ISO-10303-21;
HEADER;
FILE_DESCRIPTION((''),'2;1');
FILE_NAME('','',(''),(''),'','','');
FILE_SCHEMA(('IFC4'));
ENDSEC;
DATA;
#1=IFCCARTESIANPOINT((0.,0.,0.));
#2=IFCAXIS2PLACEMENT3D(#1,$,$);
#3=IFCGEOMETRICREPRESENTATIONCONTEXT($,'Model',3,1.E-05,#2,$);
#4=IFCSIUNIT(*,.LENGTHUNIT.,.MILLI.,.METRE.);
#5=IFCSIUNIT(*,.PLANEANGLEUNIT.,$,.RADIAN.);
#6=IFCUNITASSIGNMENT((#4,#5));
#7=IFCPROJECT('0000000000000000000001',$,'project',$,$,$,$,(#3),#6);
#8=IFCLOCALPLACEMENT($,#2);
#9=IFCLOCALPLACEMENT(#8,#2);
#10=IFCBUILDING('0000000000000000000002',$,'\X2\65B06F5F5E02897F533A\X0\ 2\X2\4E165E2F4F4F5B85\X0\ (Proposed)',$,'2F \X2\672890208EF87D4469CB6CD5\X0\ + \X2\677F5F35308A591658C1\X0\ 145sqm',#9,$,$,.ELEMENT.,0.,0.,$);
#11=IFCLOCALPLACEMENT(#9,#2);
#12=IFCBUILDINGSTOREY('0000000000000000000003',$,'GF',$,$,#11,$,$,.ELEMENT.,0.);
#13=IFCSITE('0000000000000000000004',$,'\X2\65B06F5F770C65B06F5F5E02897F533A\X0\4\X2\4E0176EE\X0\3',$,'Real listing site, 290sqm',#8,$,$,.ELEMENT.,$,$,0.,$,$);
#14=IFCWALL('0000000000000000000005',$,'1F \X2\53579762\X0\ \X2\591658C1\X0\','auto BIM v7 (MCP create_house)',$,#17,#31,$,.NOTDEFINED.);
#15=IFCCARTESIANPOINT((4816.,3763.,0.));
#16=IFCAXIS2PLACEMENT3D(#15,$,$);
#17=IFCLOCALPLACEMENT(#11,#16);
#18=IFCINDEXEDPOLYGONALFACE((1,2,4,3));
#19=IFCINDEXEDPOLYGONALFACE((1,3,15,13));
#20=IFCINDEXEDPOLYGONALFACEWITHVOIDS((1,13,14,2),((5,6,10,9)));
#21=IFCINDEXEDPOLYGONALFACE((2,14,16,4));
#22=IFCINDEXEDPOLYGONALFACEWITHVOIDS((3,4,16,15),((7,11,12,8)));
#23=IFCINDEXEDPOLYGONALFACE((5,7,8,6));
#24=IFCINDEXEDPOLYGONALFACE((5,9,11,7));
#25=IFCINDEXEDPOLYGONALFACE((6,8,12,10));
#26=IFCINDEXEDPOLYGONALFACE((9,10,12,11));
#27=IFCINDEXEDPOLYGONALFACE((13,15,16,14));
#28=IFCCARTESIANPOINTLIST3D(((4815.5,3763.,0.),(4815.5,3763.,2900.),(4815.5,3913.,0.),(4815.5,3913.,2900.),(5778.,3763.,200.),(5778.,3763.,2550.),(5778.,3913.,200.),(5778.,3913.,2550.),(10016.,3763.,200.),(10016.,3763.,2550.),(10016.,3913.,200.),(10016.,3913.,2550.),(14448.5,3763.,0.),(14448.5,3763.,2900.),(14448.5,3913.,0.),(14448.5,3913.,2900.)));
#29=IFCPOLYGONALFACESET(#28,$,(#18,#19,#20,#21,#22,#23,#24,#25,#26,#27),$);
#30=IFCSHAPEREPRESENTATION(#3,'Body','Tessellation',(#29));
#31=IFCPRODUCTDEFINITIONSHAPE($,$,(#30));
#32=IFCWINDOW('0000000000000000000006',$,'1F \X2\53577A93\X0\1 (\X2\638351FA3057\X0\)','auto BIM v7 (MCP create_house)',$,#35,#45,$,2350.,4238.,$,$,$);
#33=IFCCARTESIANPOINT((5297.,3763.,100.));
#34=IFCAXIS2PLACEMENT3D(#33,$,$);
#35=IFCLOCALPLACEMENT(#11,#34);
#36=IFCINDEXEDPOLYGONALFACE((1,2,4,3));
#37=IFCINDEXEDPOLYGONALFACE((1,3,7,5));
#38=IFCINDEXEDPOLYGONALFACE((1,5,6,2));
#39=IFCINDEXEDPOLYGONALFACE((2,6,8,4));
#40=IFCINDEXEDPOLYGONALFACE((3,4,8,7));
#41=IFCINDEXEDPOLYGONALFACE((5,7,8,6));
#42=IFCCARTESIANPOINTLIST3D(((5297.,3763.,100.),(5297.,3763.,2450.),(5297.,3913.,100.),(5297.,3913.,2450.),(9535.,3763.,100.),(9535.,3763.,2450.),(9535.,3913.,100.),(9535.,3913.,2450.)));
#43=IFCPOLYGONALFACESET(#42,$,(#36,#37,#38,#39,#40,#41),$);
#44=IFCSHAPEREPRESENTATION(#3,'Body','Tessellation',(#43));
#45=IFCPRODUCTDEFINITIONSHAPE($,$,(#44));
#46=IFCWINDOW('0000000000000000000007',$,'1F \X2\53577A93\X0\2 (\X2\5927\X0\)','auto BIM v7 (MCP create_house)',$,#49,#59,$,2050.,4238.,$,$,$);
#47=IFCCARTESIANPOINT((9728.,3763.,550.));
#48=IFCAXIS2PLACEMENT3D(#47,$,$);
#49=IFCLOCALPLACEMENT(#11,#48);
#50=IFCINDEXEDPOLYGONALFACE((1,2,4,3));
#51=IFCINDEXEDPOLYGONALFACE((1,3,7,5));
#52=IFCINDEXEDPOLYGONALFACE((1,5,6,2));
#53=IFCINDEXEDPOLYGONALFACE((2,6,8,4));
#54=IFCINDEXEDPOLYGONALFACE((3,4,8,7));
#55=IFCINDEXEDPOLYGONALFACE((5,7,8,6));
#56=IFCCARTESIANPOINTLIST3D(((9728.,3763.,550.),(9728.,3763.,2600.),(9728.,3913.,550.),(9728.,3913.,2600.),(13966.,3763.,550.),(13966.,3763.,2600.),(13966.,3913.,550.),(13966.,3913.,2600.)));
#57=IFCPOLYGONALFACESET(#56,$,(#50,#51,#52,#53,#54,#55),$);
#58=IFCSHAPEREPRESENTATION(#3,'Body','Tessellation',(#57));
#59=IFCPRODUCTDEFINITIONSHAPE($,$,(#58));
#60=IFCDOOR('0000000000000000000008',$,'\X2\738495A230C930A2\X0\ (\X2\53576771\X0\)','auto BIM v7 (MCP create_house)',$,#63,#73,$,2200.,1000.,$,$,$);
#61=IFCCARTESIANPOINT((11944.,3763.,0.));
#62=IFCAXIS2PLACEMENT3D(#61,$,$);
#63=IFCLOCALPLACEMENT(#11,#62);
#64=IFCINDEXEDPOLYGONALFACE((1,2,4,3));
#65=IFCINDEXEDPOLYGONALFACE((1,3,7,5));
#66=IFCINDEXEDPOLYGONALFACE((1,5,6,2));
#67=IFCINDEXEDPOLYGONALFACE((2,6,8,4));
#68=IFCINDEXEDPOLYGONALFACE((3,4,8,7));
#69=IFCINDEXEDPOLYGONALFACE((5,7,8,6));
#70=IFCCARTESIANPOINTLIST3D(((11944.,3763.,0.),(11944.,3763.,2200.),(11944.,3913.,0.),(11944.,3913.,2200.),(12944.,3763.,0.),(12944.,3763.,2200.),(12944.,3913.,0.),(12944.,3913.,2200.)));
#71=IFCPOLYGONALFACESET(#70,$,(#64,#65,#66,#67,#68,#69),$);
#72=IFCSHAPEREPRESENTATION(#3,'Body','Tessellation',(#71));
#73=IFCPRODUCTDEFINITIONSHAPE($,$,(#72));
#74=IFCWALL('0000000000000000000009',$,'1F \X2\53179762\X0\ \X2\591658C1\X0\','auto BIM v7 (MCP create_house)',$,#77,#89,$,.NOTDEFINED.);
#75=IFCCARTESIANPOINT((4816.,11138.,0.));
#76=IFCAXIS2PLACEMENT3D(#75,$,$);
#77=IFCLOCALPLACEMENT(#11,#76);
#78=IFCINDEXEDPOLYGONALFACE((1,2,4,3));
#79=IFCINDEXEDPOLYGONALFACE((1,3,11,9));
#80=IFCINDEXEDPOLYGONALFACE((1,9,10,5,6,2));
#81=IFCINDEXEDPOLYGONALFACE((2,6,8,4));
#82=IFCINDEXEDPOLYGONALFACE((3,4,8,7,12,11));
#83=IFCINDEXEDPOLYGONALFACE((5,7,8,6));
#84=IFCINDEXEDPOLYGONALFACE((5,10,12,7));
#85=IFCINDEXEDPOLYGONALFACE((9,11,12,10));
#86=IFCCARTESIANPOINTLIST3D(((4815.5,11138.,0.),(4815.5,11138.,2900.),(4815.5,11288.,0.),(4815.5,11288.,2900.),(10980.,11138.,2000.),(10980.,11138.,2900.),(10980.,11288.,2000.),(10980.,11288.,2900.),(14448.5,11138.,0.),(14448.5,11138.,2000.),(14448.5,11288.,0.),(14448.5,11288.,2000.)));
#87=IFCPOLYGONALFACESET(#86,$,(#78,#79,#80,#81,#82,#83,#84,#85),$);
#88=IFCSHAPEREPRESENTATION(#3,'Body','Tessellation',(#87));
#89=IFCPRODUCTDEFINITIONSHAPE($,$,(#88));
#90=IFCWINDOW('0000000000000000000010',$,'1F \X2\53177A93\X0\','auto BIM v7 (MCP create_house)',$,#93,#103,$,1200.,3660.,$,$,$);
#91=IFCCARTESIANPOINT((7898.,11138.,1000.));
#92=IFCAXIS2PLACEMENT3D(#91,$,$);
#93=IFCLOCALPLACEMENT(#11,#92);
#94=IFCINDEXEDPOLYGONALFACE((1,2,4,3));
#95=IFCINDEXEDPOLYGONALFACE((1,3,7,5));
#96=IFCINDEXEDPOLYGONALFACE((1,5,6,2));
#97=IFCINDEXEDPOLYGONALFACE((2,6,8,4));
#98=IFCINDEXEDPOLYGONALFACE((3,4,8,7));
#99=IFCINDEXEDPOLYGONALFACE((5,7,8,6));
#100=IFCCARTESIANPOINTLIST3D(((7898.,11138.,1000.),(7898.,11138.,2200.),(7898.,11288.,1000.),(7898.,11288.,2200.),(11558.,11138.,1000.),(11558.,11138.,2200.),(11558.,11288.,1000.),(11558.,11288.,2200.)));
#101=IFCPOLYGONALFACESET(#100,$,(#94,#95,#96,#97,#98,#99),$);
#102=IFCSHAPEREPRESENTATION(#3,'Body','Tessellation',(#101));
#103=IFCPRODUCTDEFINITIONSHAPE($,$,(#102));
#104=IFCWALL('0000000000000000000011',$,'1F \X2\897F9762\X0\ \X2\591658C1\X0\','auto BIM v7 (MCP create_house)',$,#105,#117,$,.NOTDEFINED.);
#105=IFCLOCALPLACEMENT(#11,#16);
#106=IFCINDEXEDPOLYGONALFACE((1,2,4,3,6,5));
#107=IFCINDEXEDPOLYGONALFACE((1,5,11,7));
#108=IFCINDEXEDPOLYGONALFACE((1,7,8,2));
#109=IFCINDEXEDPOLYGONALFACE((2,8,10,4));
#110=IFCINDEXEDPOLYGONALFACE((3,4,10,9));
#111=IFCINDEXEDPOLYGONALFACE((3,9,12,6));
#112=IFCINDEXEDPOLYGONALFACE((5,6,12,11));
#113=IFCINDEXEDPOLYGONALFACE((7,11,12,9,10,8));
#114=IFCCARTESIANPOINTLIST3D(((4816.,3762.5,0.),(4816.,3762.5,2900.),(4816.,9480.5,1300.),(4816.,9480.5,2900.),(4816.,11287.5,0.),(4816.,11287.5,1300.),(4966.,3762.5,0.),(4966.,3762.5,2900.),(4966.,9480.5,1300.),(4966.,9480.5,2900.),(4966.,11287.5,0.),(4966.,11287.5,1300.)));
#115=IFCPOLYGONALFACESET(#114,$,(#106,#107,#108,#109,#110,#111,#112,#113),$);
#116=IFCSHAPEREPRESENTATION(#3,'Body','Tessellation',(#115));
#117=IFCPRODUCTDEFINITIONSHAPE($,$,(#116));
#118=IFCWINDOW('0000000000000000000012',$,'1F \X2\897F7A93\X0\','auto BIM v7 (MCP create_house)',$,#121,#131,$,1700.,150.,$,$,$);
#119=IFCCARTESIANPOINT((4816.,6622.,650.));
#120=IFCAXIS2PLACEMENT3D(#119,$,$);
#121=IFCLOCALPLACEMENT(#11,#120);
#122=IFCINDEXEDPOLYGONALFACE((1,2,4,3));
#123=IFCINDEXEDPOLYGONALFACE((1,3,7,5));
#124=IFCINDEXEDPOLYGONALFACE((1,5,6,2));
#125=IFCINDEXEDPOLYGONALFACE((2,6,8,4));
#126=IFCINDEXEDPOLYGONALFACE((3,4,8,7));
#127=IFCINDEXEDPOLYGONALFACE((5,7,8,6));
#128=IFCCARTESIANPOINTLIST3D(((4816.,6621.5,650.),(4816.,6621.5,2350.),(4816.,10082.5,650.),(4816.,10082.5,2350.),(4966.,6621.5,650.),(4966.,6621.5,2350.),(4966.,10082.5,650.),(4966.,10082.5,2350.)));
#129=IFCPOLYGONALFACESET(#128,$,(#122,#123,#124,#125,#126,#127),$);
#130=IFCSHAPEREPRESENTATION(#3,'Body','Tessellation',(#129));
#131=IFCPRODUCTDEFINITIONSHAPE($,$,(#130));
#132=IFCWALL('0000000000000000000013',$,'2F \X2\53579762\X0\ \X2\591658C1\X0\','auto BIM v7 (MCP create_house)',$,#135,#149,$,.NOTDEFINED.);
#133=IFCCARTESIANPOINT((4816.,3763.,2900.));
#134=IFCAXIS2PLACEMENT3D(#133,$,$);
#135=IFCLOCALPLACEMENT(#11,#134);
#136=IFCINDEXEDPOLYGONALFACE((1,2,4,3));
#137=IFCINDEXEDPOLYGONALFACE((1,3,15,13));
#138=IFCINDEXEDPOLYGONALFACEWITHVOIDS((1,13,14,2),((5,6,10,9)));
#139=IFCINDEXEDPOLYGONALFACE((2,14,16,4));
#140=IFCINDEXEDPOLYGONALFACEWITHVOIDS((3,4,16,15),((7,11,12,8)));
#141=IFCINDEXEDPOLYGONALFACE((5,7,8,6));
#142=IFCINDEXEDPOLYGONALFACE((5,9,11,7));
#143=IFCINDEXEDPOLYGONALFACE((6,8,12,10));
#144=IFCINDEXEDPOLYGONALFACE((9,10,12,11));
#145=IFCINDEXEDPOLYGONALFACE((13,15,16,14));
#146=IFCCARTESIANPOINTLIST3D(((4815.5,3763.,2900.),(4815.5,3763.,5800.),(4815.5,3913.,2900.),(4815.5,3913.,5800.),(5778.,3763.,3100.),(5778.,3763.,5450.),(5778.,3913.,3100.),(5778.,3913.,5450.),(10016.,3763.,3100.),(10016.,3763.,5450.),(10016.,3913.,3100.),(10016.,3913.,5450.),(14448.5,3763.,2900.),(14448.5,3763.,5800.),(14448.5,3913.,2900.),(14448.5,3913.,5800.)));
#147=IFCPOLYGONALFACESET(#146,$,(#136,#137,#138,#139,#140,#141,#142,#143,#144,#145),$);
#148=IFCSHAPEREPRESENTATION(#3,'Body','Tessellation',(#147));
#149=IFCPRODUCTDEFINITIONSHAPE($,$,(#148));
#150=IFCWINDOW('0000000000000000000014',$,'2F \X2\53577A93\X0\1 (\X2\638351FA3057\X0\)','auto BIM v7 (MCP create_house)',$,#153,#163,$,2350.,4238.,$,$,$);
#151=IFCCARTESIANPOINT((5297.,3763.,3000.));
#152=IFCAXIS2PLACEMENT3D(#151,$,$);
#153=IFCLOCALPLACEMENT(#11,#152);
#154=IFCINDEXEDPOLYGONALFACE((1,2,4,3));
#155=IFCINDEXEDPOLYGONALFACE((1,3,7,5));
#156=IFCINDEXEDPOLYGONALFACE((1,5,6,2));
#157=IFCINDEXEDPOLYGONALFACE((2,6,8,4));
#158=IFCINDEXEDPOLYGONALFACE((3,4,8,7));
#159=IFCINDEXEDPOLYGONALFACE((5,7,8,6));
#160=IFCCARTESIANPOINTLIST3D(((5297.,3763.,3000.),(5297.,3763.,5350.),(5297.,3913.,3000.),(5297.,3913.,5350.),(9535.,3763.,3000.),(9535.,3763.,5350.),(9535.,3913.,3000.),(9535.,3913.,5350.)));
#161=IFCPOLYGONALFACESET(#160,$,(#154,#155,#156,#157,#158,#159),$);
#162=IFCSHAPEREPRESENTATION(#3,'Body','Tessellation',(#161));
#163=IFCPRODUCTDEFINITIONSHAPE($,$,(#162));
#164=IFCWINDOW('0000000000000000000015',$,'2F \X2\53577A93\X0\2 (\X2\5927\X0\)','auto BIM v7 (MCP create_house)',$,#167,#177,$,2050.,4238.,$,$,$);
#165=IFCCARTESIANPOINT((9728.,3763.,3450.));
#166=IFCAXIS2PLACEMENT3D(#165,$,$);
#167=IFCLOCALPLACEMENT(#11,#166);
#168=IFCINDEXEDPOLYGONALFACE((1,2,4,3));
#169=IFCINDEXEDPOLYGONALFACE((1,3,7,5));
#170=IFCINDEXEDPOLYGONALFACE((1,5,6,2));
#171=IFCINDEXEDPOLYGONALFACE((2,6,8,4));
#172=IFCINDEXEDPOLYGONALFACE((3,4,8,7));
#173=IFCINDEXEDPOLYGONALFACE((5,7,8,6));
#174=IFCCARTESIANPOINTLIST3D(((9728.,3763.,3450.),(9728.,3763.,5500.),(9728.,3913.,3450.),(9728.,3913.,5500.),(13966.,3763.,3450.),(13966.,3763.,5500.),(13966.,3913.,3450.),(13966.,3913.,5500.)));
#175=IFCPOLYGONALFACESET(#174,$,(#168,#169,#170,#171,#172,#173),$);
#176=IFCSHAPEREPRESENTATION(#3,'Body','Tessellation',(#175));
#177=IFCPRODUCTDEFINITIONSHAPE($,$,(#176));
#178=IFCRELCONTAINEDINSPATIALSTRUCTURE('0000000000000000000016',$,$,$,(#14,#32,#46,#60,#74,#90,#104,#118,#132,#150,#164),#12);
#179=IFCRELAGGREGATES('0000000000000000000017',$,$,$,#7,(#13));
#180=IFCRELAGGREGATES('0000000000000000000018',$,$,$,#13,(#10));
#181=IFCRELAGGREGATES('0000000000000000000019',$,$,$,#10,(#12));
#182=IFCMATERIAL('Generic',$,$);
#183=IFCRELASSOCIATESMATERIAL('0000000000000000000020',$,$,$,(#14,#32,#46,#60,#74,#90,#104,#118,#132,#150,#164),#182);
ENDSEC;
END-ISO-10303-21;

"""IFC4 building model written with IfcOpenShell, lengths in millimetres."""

from ifc_helpers import new_model, si_unit, frame, frame_2d, origin, place, context, project, spatial, rectangle, extrude, material, element, fill, save


model = new_model("IFC4")

# Units and contexts
model_context = context("Model", 3, precision=1e-05, world=origin())
ifc_project = project(units=[si_unit("LENGTHUNIT", "METRE", prefix="MILLI"), si_unit("PLANEANGLEUNIT", "RADIAN")], contexts=[model_context])

# Site, building, storey
site_placement = place(None, origin())
site = spatial("IfcSite", under=ifc_project, at=site_placement, Name="新潟県新潟市西区4丁目3", ObjectType="Real listing site, 290sqm", CompositionType="ELEMENT", RefElevation=0.0)
building_placement = place(site_placement, origin())
building = spatial("IfcBuilding", under=site, at=building_placement, Name="新潟市西区 2世帯住宅 (Proposed)", ObjectType="2F 木造軸組構法 + 板張り外壁 145sqm", CompositionType="ELEMENT", ElevationOfRefHeight=0.0, ElevationOfTerrain=0.0)
storey_placement = place(building_placement, origin())
storey = spatial("IfcBuildingStorey", under=building, at=storey_placement, Name="GF", CompositionType="ELEMENT", Elevation=0.0)

# Shared definitions
ifc_material = material(Name="Generic")

# Wall, openings, windows, door
wall_1_placement = place(storey_placement, frame((4816.0, 3763.0, 0.0)))
wall_1 = element("IfcWall", 1, at=wall_1_placement, inside=storey, material=ifc_material, Name="1F 南面 外壁", Description="auto BIM v7 (MCP create_house)", PredefinedType="NOTDEFINED", context=model_context, shape_type="SweptSolid", body=[
    extrude(rectangle(XDim=9633.0, YDim=150.0, at=frame_2d((4816.0, 75.0))), frame((4816.0, 3763.0, 0.0)), (0.0, 0.0, 1.0), 2900.0),
])
opening_1_placement = place(storey_placement, frame((5297.0, 3763.0, 100.0)))
opening_1 = element("IfcOpeningElement", 2, at=opening_1_placement, cuts=wall_1, PredefinedType="NOTDEFINED", context=model_context, shape_type="SweptSolid", body=[
    extrude(rectangle(XDim=4238.0, YDim=150.0, at=frame_2d((2119.0, 75.0))), frame((5297.0, 3763.0, 100.0)), (0.0, 0.0, 1.0), 2350.0),
])
opening_2_placement = place(storey_placement, frame((9728.0, 3763.0, 550.0)))
opening_2 = element("IfcOpeningElement", 3, at=opening_2_placement, cuts=wall_1, PredefinedType="NOTDEFINED", context=model_context, shape_type="SweptSolid", body=[
    extrude(rectangle(XDim=4238.0, YDim=150.0, at=frame_2d((2119.0, 75.0))), frame((9728.0, 3763.0, 550.0)), (0.0, 0.0, 1.0), 2050.0),
])
opening_3_placement = place(storey_placement, frame((11944.0, 3763.0, 0.0)))
opening_3 = element("IfcOpeningElement", 4, at=opening_3_placement, cuts=wall_1, PredefinedType="NOTDEFINED", context=model_context, shape_type="SweptSolid", body=[
    extrude(rectangle(XDim=1000.0, YDim=150.0, at=frame_2d((500.0, 75.0))), frame((11944.0, 3763.0, 0.0)), (0.0, 0.0, 1.0), 2200.0),
])
window_1_placement = place(storey_placement, frame((5297.0, 3763.0, 100.0)))
window_1 = element("IfcWindow", 5, at=window_1_placement, inside=storey, material=ifc_material, Name="1F 南窓1 (掃出し)", Description="auto BIM v7 (MCP create_house)", OverallHeight=2350.0, OverallWidth=4238.0, context=model_context, shape_type="SweptSolid", body=[
    extrude(rectangle(XDim=4238.0, YDim=150.0, at=frame_2d((2119.0, 75.0))), frame((5297.0, 3763.0, 100.0)), (0.0, 0.0, 1.0), 2350.0),
])
fill(opening_1, window_1)
window_2_placement = place(storey_placement, frame((9728.0, 3763.0, 550.0)))
window_2 = element("IfcWindow", 6, at=window_2_placement, inside=storey, material=ifc_material, Name="1F 南窓2 (大)", Description="auto BIM v7 (MCP create_house)", OverallHeight=2050.0, OverallWidth=4238.0, context=model_context, shape_type="SweptSolid", body=[
    extrude(rectangle(XDim=4238.0, YDim=150.0, at=frame_2d((2119.0, 75.0))), frame((9728.0, 3763.0, 550.0)), (0.0, 0.0, 1.0), 2050.0),
])
fill(opening_2, window_2)
door_placement = place(storey_placement, frame((11944.0, 3763.0, 0.0)))
door = element("IfcDoor", 7, at=door_placement, inside=storey, material=ifc_material, Name="玄関ドア (南東)", Description="auto BIM v7 (MCP create_house)", OverallHeight=2200.0, OverallWidth=1000.0, context=model_context, shape_type="SweptSolid", body=[
    extrude(rectangle(XDim=1000.0, YDim=150.0, at=frame_2d((500.0, 75.0))), frame((11944.0, 3763.0, 0.0)), (0.0, 0.0, 1.0), 2200.0),
])
fill(opening_3, door)

# Walls, openings, windows
wall_2_placement = place(storey_placement, frame((4816.0, 11138.0, 0.0)))
wall_2 = element("IfcWall", 8, at=wall_2_placement, inside=storey, material=ifc_material, Name="1F 北面 外壁", Description="auto BIM v7 (MCP create_house)", PredefinedType="NOTDEFINED", context=model_context, shape_type="SweptSolid", body=[
    extrude(rectangle(XDim=9633.0, YDim=150.0, at=frame_2d((4816.0, 75.0))), frame((4816.0, 11138.0, 0.0)), (0.0, 0.0, 1.0), 2900.0),
])
opening_4_placement = place(storey_placement, frame((7898.0, 11138.0, 1000.0)))
opening_4 = element("IfcOpeningElement", 9, at=opening_4_placement, cuts=wall_2, PredefinedType="NOTDEFINED", context=model_context, shape_type="SweptSolid", body=[
    extrude(rectangle(XDim=3660.0, YDim=150.0, at=frame_2d((1830.0, 75.0))), frame((7898.0, 11138.0, 1000.0)), (0.0, 0.0, 1.0), 1200.0),
])
window_3_placement = place(storey_placement, frame((7898.0, 11138.0, 1000.0)))
window_3 = element("IfcWindow", 10, at=window_3_placement, inside=storey, material=ifc_material, Name="1F 北窓", Description="auto BIM v7 (MCP create_house)", OverallHeight=1200.0, OverallWidth=3660.0, context=model_context, shape_type="SweptSolid", body=[
    extrude(rectangle(XDim=3660.0, YDim=150.0, at=frame_2d((1830.0, 75.0))), frame((7898.0, 11138.0, 1000.0)), (0.0, 0.0, 1.0), 1200.0),
])
fill(opening_4, window_3)
wall_3_placement = place(storey_placement, frame((4816.0, 3763.0, 0.0)))
wall_3 = element("IfcWall", 11, at=wall_3_placement, inside=storey, material=ifc_material, Name="1F 西面 外壁", Description="auto BIM v7 (MCP create_house)", PredefinedType="NOTDEFINED", context=model_context, shape_type="SweptSolid", body=[
    extrude(rectangle(XDim=150.0, YDim=7525.0, at=frame_2d((75.0, 3762.0))), frame((4816.0, 3763.0, 0.0)), (0.0, 0.0, 1.0), 2900.0),
])
opening_5_placement = place(storey_placement, frame((4816.0, 6622.0, 650.0)))
opening_5 = element("IfcOpeningElement", 12, at=opening_5_placement, cuts=wall_3, PredefinedType="NOTDEFINED", context=model_context, shape_type="SweptSolid", body=[
    extrude(rectangle(XDim=150.0, YDim=3461.0, at=frame_2d((75.0, 1730.0))), frame((4816.0, 6622.0, 650.0)), (0.0, 0.0, 1.0), 1700.0),
])
window_4_placement = place(storey_placement, frame((4816.0, 6622.0, 650.0)))
window_4 = element("IfcWindow", 13, at=window_4_placement, inside=storey, material=ifc_material, Name="1F 西窓", Description="auto BIM v7 (MCP create_house)", OverallHeight=1700.0, OverallWidth=150.0, context=model_context, shape_type="SweptSolid", body=[
    extrude(rectangle(XDim=150.0, YDim=3461.0, at=frame_2d((75.0, 1730.0))), frame((4816.0, 6622.0, 650.0)), (0.0, 0.0, 1.0), 1700.0),
])
fill(opening_5, window_4)

# Wall, openings, windows
wall_4_placement = place(storey_placement, frame((4816.0, 3763.0, 2900.0)))
wall_4 = element("IfcWall", 14, at=wall_4_placement, inside=storey, material=ifc_material, Name="2F 南面 外壁", Description="auto BIM v7 (MCP create_house)", PredefinedType="NOTDEFINED", context=model_context, shape_type="SweptSolid", body=[
    extrude(rectangle(XDim=9633.0, YDim=150.0, at=frame_2d((4816.0, 75.0))), frame((4816.0, 3763.0, 2900.0)), (0.0, 0.0, 1.0), 2900.0),
])
opening_6_placement = place(storey_placement, frame((5297.0, 3763.0, 3000.0)))
opening_6 = element("IfcOpeningElement", 15, at=opening_6_placement, cuts=wall_4, PredefinedType="NOTDEFINED", context=model_context, shape_type="SweptSolid", body=[
    extrude(rectangle(XDim=4238.0, YDim=150.0, at=frame_2d((2119.0, 75.0))), frame((5297.0, 3763.0, 3000.0)), (0.0, 0.0, 1.0), 2350.0),
])
opening_7_placement = place(storey_placement, frame((9728.0, 3763.0, 3450.0)))
opening_7 = element("IfcOpeningElement", 16, at=opening_7_placement, cuts=wall_4, PredefinedType="NOTDEFINED", context=model_context, shape_type="SweptSolid", body=[
    extrude(rectangle(XDim=4238.0, YDim=150.0, at=frame_2d((2119.0, 75.0))), frame((9728.0, 3763.0, 3450.0)), (0.0, 0.0, 1.0), 2050.0),
])
window_5_placement = place(storey_placement, frame((5297.0, 3763.0, 3000.0)))
window_5 = element("IfcWindow", 17, at=window_5_placement, inside=storey, material=ifc_material, Name="2F 南窓1 (掃出し)", Description="auto BIM v7 (MCP create_house)", OverallHeight=2350.0, OverallWidth=4238.0, context=model_context, shape_type="SweptSolid", body=[
    extrude(rectangle(XDim=4238.0, YDim=150.0, at=frame_2d((2119.0, 75.0))), frame((5297.0, 3763.0, 3000.0)), (0.0, 0.0, 1.0), 2350.0),
])
fill(opening_6, window_5)
window_6_placement = place(storey_placement, frame((9728.0, 3763.0, 3450.0)))
window_6 = element("IfcWindow", 18, at=window_6_placement, inside=storey, material=ifc_material, Name="2F 南窓2 (大)", Description="auto BIM v7 (MCP create_house)", OverallHeight=2050.0, OverallWidth=4238.0, context=model_context, shape_type="SweptSolid", body=[
    extrude(rectangle(XDim=4238.0, YDim=150.0, at=frame_2d((2119.0, 75.0))), frame((9728.0, 3763.0, 3450.0)), (0.0, 0.0, 1.0), 2050.0),
])
fill(opening_7, window_6)

save(model, "model.ifc")
